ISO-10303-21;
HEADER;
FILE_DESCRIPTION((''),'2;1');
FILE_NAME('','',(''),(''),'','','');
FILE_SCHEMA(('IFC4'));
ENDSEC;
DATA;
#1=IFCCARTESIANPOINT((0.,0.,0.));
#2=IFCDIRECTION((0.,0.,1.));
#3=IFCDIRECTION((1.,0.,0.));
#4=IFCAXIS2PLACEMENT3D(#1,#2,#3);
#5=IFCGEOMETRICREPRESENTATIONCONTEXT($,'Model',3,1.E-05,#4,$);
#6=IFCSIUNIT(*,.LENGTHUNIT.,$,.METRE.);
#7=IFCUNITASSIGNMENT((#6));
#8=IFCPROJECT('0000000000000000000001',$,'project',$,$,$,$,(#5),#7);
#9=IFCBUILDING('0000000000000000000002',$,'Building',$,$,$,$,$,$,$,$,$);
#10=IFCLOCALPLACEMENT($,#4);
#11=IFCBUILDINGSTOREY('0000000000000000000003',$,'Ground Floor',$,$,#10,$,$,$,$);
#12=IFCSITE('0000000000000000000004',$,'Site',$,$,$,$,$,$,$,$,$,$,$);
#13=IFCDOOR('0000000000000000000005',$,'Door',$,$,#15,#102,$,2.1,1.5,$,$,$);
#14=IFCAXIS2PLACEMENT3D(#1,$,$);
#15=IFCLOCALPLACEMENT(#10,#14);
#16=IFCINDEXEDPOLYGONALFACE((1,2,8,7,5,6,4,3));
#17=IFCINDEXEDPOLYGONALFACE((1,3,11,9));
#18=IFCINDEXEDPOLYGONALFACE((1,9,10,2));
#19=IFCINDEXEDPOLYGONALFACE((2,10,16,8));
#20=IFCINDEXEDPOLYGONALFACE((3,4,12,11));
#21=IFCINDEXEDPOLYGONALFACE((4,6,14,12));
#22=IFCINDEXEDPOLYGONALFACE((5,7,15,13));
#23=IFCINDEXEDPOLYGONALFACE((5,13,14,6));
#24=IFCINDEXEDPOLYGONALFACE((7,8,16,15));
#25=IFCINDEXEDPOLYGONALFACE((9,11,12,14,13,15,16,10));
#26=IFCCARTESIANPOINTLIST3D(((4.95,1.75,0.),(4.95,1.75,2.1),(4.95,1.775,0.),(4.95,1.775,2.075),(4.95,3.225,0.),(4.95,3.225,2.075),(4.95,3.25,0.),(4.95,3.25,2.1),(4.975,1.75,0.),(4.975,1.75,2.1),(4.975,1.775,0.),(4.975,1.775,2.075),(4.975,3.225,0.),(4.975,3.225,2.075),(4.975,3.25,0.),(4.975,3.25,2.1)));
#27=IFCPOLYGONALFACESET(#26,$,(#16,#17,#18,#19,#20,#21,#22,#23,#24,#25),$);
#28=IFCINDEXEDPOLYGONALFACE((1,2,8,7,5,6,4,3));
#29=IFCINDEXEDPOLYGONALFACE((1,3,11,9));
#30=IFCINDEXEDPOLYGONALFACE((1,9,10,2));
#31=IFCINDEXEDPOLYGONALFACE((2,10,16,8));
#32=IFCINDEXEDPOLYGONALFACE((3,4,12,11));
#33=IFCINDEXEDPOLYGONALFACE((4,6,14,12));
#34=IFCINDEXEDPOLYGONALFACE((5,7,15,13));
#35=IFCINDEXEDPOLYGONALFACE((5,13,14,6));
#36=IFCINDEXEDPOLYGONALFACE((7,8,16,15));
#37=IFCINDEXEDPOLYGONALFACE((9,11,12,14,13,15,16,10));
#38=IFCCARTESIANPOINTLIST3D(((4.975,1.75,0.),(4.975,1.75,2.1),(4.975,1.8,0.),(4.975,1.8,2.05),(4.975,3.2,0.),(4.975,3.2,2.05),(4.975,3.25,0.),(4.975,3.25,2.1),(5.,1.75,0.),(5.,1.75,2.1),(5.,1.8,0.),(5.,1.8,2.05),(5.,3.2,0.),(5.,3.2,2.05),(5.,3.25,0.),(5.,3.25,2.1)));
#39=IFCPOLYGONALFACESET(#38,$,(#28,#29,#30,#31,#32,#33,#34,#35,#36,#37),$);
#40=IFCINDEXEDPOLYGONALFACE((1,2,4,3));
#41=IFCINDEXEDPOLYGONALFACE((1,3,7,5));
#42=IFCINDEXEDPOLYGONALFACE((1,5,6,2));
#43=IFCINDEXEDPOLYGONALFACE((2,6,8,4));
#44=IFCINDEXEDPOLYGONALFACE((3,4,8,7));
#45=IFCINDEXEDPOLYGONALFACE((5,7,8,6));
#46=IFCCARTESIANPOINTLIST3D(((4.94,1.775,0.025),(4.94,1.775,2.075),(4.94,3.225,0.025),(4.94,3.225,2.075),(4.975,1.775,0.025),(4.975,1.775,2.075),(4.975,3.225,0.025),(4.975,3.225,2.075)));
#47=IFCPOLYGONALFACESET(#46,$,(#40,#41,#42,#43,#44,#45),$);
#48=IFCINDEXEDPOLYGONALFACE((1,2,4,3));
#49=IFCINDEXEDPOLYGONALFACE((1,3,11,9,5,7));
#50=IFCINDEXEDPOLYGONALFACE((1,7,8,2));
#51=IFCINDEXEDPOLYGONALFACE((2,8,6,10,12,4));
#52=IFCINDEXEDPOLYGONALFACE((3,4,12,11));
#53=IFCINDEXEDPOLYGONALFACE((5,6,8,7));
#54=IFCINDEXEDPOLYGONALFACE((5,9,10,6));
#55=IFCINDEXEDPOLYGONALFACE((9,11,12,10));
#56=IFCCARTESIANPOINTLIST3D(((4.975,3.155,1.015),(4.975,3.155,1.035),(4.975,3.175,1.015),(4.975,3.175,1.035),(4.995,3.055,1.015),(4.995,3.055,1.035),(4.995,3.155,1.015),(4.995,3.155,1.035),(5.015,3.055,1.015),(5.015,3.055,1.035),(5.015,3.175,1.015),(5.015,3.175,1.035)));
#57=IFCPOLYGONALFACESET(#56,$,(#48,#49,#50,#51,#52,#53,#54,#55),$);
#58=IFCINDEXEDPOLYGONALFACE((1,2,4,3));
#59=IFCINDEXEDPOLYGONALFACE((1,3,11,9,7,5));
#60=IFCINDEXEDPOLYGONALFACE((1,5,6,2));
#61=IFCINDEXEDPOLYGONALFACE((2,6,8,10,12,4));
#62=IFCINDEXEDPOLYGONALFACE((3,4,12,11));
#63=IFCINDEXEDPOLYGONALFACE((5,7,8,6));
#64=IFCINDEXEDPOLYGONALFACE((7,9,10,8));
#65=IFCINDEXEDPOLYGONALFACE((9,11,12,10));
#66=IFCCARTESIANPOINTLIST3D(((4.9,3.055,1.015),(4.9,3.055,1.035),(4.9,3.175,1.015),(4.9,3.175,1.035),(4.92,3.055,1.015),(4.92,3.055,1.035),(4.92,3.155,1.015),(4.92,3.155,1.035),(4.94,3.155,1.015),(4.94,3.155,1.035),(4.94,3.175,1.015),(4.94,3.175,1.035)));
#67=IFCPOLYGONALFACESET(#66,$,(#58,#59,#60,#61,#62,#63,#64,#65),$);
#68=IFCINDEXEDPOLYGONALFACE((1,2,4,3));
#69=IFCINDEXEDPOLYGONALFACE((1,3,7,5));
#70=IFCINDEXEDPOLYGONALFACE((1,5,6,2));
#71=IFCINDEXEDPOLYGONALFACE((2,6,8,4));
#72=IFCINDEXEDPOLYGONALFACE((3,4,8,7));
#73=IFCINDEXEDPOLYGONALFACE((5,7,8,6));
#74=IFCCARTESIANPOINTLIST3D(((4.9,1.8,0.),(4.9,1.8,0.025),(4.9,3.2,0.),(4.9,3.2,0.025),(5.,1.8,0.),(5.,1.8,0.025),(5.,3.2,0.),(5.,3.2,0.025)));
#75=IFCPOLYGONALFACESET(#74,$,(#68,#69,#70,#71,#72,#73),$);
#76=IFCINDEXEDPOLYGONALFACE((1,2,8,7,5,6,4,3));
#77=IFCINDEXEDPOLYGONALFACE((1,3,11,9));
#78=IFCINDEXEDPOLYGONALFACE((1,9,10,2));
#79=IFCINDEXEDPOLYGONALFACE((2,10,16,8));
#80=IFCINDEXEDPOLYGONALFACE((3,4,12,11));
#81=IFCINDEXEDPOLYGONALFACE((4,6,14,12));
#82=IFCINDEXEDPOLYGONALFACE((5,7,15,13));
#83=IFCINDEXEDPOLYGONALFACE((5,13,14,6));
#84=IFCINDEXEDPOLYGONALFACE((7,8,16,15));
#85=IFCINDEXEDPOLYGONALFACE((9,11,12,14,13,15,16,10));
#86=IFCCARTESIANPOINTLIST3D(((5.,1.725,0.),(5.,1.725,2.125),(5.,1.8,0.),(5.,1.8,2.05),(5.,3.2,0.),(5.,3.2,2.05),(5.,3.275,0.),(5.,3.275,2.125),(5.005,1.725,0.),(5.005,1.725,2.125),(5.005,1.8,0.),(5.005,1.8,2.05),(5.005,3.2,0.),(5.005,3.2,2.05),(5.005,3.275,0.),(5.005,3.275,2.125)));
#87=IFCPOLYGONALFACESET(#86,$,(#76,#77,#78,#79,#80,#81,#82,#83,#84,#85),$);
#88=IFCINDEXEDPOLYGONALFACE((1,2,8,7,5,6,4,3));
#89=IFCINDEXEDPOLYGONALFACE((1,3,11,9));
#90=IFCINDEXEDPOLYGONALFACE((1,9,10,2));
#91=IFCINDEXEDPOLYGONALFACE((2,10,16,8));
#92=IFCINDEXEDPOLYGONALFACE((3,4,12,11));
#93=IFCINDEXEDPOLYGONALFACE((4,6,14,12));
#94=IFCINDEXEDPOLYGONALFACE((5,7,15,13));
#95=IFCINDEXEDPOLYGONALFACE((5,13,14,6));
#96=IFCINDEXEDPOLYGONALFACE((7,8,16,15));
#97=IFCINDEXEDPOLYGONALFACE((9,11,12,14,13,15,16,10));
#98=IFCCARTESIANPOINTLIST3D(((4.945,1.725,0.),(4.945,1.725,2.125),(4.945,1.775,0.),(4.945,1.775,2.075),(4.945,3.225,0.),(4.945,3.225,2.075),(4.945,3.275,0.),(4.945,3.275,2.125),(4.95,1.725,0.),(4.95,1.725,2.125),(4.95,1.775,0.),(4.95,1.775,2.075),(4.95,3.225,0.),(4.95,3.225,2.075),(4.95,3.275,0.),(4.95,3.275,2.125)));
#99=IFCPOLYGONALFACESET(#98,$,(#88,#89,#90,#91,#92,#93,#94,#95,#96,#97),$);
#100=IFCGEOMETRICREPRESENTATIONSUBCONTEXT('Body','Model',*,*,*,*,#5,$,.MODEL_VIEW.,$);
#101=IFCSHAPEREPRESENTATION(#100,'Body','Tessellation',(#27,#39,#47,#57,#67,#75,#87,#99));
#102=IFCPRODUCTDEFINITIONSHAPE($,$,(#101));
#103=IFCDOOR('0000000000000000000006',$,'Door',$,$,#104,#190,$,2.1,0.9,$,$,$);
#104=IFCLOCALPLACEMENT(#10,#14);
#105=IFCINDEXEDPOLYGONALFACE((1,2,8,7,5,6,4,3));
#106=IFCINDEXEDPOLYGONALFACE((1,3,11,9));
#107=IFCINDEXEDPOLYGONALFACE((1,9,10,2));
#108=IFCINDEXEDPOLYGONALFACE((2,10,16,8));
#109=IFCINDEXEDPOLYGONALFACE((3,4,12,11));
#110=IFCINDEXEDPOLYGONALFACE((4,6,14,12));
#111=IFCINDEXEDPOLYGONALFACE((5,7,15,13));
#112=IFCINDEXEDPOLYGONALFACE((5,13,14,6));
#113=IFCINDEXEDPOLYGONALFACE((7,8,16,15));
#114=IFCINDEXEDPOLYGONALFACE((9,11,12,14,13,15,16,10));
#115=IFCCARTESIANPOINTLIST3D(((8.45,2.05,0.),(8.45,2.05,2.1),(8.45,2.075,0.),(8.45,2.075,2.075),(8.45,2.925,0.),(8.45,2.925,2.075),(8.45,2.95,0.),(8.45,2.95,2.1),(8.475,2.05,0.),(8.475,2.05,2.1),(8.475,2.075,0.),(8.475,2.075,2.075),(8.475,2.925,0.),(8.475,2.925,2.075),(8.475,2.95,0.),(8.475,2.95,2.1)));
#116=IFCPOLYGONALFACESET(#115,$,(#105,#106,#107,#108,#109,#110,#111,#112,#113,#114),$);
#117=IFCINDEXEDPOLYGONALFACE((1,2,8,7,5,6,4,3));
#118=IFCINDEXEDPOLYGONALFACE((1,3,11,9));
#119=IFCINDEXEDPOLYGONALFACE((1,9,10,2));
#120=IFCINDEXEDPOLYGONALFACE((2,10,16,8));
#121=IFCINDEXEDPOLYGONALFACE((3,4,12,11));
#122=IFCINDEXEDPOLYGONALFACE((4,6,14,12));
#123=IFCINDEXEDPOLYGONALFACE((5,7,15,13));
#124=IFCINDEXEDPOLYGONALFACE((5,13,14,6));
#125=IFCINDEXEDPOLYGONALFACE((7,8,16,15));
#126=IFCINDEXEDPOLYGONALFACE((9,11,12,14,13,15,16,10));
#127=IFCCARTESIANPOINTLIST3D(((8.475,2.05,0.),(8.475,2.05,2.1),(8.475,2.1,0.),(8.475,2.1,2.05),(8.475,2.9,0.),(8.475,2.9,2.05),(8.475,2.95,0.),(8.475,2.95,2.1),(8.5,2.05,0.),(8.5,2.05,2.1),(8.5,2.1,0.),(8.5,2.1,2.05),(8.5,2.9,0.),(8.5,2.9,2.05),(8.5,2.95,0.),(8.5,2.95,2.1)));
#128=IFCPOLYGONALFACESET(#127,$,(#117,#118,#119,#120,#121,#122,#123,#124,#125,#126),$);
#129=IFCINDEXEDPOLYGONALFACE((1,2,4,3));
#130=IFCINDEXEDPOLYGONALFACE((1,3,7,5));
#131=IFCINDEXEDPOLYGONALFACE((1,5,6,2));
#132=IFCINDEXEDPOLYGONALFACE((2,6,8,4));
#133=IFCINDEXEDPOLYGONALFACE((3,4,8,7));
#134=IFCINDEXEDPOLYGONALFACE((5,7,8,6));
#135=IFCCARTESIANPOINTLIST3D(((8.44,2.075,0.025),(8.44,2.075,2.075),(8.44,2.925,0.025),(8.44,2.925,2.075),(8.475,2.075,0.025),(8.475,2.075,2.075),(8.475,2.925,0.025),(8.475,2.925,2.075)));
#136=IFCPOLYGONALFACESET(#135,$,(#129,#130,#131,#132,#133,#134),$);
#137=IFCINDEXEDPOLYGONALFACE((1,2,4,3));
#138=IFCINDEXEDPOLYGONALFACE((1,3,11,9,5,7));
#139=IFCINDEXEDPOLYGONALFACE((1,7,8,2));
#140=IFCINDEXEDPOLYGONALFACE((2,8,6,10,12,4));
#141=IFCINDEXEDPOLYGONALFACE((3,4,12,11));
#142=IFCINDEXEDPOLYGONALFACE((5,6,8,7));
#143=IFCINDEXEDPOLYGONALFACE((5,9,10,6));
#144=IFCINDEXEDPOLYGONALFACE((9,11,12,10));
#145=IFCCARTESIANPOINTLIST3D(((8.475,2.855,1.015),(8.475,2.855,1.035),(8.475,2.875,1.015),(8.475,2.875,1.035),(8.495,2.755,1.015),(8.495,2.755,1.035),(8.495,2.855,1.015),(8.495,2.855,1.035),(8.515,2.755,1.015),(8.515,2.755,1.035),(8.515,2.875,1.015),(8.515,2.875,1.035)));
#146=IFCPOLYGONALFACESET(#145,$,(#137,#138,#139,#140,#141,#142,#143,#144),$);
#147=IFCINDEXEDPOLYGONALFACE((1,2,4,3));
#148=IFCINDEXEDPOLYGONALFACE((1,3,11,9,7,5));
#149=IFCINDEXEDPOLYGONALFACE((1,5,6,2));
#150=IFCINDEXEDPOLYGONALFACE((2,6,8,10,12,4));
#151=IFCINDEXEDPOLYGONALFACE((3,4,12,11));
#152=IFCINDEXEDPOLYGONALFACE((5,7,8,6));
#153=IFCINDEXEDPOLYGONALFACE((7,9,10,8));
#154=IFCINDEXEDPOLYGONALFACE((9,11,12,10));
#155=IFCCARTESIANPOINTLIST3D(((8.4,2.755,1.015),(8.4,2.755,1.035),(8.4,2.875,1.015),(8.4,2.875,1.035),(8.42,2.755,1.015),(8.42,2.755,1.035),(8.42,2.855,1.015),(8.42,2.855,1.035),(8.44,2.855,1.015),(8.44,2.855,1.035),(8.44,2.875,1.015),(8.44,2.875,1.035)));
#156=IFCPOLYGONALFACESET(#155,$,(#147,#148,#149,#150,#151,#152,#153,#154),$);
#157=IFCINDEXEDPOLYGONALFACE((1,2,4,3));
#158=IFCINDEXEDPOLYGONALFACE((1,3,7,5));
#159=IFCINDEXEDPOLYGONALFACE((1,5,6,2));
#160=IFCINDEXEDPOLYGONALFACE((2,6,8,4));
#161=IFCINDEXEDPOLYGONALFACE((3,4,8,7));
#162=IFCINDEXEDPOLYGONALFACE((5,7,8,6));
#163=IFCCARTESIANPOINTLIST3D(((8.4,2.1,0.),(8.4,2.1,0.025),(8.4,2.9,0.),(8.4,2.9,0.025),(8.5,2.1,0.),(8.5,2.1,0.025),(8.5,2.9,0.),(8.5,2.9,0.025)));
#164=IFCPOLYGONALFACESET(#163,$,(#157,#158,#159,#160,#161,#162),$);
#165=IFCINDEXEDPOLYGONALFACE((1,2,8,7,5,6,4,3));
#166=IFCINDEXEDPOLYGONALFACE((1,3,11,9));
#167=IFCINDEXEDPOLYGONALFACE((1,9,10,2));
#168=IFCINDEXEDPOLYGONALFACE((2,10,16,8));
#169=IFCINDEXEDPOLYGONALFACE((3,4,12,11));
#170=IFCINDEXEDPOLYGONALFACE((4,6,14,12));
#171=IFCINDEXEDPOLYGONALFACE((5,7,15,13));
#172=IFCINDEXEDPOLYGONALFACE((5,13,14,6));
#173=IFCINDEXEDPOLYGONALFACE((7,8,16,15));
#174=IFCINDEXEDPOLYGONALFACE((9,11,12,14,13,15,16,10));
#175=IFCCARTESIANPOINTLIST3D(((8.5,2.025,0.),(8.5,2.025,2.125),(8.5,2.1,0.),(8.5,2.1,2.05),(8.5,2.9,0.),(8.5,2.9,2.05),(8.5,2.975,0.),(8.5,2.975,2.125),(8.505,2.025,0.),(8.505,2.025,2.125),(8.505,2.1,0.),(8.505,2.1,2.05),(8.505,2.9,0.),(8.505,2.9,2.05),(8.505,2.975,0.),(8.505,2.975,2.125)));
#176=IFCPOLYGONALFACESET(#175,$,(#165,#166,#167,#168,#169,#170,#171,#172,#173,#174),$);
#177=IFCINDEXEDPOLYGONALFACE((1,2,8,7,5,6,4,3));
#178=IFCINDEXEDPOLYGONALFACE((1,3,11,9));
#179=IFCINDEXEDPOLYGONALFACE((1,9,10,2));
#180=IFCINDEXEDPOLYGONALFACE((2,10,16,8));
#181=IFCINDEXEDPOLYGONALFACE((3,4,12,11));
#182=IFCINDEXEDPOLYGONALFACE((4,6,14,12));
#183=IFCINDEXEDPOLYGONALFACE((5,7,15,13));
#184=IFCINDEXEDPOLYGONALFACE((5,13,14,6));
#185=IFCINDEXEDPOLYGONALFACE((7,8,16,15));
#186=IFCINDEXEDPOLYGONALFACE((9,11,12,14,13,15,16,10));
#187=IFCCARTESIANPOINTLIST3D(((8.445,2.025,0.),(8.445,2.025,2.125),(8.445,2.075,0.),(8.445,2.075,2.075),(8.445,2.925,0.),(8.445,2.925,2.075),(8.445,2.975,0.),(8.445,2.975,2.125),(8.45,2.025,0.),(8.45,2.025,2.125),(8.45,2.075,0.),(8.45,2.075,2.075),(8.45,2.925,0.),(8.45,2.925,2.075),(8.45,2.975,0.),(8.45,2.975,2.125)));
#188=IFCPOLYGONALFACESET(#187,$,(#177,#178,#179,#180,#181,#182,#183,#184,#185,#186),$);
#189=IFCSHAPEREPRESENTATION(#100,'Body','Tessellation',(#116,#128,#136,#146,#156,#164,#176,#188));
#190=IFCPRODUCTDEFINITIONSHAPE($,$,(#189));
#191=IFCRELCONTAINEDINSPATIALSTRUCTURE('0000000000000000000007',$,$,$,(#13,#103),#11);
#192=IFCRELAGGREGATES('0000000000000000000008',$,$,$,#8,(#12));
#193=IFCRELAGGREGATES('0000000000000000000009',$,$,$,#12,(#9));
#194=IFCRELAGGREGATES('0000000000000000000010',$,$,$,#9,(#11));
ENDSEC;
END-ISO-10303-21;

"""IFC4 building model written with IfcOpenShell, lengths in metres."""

from ifc_helpers import new_model, si_unit, frame, origin_with_axes, place, context, subcontext, project, spatial, line, indexed_curve, outline, extrude, element, save


model = new_model("IFC4")

# Units and contexts
model_context = context("Model", 3, precision=1e-05, world=origin_with_axes())
body_context = subcontext(model_context, "Body", "Model", "MODEL_VIEW")
ifc_project = project(units=[si_unit("LENGTHUNIT", "METRE")], contexts=[model_context])

# Site, building, storey
site = spatial("IfcSite", under=ifc_project, Name="Site")
building = spatial("IfcBuilding", under=site, Name="Building")
storey_placement = place(None, origin_with_axes())
storey = spatial("IfcBuildingStorey", under=building, at=storey_placement, Name="Ground Floor")

# Doors
door_1_placement = place(storey_placement, frame((5.0, 1.75, 0.0), z_axis=(0.0, 0.0, 1.0), x_axis=(0.0, 1.0, 0.0)))
element("IfcDoor", 1, at=door_1_placement, inside=storey, Name="Door", OverallHeight=2.1, OverallWidth=1.5, context=body_context, shape_type="SweptSolid", body=[
    extrude(outline(indexed_curve([(0.0, 0.0), (0.0, 2.1), (1.5, 2.1), (1.5, 0.0), (1.475, 0.0), (1.475, 2.075), (0.025, 2.075), (0.025, 0.0)], segments=[line(1, 2, 3, 4, 5, 6, 7, 8, 1)])), frame((0.0, 0.025, 0.0), z_axis=(0.0, -1.0, 0.0), x_axis=(1.0, 0.0, 0.0)), (0.0, 0.0, -1.0), 0.025),
    extrude(outline(indexed_curve([(0.0, 0.0), (0.0, 2.1), (1.5, 2.1), (1.5, 0.0), (1.45, 0.0), (1.45, 2.05), (0.05, 2.05), (0.05, 0.0)], segments=[line(1, 2, 3, 4, 5, 6, 7, 8, 1)])), frame((0.0, 0.0, 0.0), z_axis=(0.0, -1.0, 0.0), x_axis=(1.0, 0.0, 0.0)), (0.0, 0.0, -1.0), 0.025),
    extrude(outline(indexed_curve([(0.0, 0.0), (1.45, 0.0), (1.45, 0.035), (0.0, 0.035)], segments=[line(1, 2, 3, 4, 1)])), frame((0.025, 0.025, 0.025), z_axis=(0.0, 0.0, 1.0), x_axis=(1.0, 0.0, 0.0)), (0.0, 0.0, 1.0), 2.05),
    extrude(outline(indexed_curve([(0.0, 0.0), (0.0, -0.04), (-0.12, -0.04), (-0.12, -0.02), (-0.02, -0.02), (-0.02, 0.0)], segments=[line(1, 2, 3, 4, 5, 6, 1)])), frame((1.425, 0.025, 1.015), z_axis=(0.0, 0.0, 1.0), x_axis=(1.0, 0.0, 0.0)), (0.0, 0.0, 1.0), 0.02),
    extrude(outline(indexed_curve([(0.0, 0.0), (0.0, 0.04), (-0.12, 0.04), (-0.12, 0.02), (-0.02, 0.02), (-0.02, 0.0)], segments=[line(1, 2, 3, 4, 5, 6, 1)])), frame((1.425, 0.06, 1.015), z_axis=(0.0, 0.0, 1.0), x_axis=(1.0, 0.0, 0.0)), (0.0, 0.0, 1.0), 0.02),
    extrude(outline(indexed_curve([(0.0, 0.0), (1.4, 0.0), (1.4, 0.1), (0.0, 0.1)], segments=[line(1, 2, 3, 4, 1)])), frame((0.05, 0.0, 0.0), z_axis=(0.0, 0.0, 1.0), x_axis=(1.0, 0.0, 0.0)), (0.0, 0.0, 1.0), 0.025),
    extrude(outline(indexed_curve([(0.0, 0.0), (0.0, 2.125), (1.55, 2.125), (1.55, 0.0), (1.475, 0.0), (1.475, 2.05), (0.075, 2.05), (0.075, 0.0)], segments=[line(1, 2, 3, 4, 5, 6, 7, 8, 1)])), frame((-0.025, -0.005, 0.0), z_axis=(0.0, -1.0, 0.0), x_axis=(1.0, 0.0, 0.0)), (0.0, 0.0, -1.0), 0.005),
    extrude(outline(indexed_curve([(0.0, 0.0), (0.0, 2.125), (1.55, 2.125), (1.55, 0.0), (1.5, 0.0), (1.5, 2.075), (0.05, 2.075), (0.05, 0.0)], segments=[line(1, 2, 3, 4, 5, 6, 7, 8, 1)])), frame((-0.025, 0.05, 0.0), z_axis=(0.0, -1.0, 0.0), x_axis=(1.0, 0.0, 0.0)), (0.0, 0.0, -1.0), 0.005),
])
door_2_placement = place(storey_placement, frame((8.5, 2.05, 0.0), z_axis=(0.0, 0.0, 1.0), x_axis=(0.0, 1.0, 0.0)))
element("IfcDoor", 2, at=door_2_placement, inside=storey, Name="Door", OverallHeight=2.1, OverallWidth=0.9, context=body_context, shape_type="SweptSolid", body=[
    extrude(outline(indexed_curve([(0.0, 0.0), (0.0, 2.1), (0.9, 2.1), (0.9, 0.0), (0.875, 0.0), (0.875, 2.075), (0.025, 2.075), (0.025, 0.0)], segments=[line(1, 2, 3, 4, 5, 6, 7, 8, 1)])), frame((0.0, 0.025, 0.0), z_axis=(0.0, -1.0, 0.0), x_axis=(1.0, 0.0, 0.0)), (0.0, 0.0, -1.0), 0.025),
    extrude(outline(indexed_curve([(0.0, 0.0), (0.0, 2.1), (0.9, 2.1), (0.9, 0.0), (0.85, 0.0), (0.85, 2.05), (0.05, 2.05), (0.05, 0.0)], segments=[line(1, 2, 3, 4, 5, 6, 7, 8, 1)])), frame((0.0, 0.0, 0.0), z_axis=(0.0, -1.0, 0.0), x_axis=(1.0, 0.0, 0.0)), (0.0, 0.0, -1.0), 0.025),
    extrude(outline(indexed_curve([(0.0, 0.0), (0.85, 0.0), (0.85, 0.035), (0.0, 0.035)], segments=[line(1, 2, 3, 4, 1)])), frame((0.025, 0.025, 0.025), z_axis=(0.0, 0.0, 1.0), x_axis=(1.0, 0.0, 0.0)), (0.0, 0.0, 1.0), 2.05),
    extrude(outline(indexed_curve([(0.0, 0.0), (0.0, -0.04), (-0.12, -0.04), (-0.12, -0.02), (-0.02, -0.02), (-0.02, 0.0)], segments=[line(1, 2, 3, 4, 5, 6, 1)])), frame((0.825, 0.025, 1.015), z_axis=(0.0, 0.0, 1.0), x_axis=(1.0, 0.0, 0.0)), (0.0, 0.0, 1.0), 0.02),
    extrude(outline(indexed_curve([(0.0, 0.0), (0.0, 0.04), (-0.12, 0.04), (-0.12, 0.02), (-0.02, 0.02), (-0.02, 0.0)], segments=[line(1, 2, 3, 4, 5, 6, 1)])), frame((0.825, 0.06, 1.015), z_axis=(0.0, 0.0, 1.0), x_axis=(1.0, 0.0, 0.0)), (0.0, 0.0, 1.0), 0.02),
    extrude(outline(indexed_curve([(0.0, 0.0), (0.8, 0.0), (0.8, 0.1), (0.0, 0.1)], segments=[line(1, 2, 3, 4, 1)])), frame((0.05, 0.0, 0.0), z_axis=(0.0, 0.0, 1.0), x_axis=(1.0, 0.0, 0.0)), (0.0, 0.0, 1.0), 0.025),
    extrude(outline(indexed_curve([(0.0, 0.0), (0.0, 2.125), (0.95, 2.125), (0.95, 0.0), (0.875, 0.0), (0.875, 2.05), (0.075, 2.05), (0.075, 0.0)], segments=[line(1, 2, 3, 4, 5, 6, 7, 8, 1)])), frame((-0.025, -0.005, 0.0), z_axis=(0.0, -1.0, 0.0), x_axis=(1.0, 0.0, 0.0)), (0.0, 0.0, -1.0), 0.005),
    extrude(outline(indexed_curve([(0.0, 0.0), (0.0, 2.125), (0.95, 2.125), (0.95, 0.0), (0.9, 0.0), (0.9, 2.075), (0.05, 2.075), (0.05, 0.0)], segments=[line(1, 2, 3, 4, 5, 6, 7, 8, 1)])), frame((-0.025, 0.05, 0.0), z_axis=(0.0, -1.0, 0.0), x_axis=(1.0, 0.0, 0.0)), (0.0, 0.0, -1.0), 0.005),
])

save(model, "model.ifc")
